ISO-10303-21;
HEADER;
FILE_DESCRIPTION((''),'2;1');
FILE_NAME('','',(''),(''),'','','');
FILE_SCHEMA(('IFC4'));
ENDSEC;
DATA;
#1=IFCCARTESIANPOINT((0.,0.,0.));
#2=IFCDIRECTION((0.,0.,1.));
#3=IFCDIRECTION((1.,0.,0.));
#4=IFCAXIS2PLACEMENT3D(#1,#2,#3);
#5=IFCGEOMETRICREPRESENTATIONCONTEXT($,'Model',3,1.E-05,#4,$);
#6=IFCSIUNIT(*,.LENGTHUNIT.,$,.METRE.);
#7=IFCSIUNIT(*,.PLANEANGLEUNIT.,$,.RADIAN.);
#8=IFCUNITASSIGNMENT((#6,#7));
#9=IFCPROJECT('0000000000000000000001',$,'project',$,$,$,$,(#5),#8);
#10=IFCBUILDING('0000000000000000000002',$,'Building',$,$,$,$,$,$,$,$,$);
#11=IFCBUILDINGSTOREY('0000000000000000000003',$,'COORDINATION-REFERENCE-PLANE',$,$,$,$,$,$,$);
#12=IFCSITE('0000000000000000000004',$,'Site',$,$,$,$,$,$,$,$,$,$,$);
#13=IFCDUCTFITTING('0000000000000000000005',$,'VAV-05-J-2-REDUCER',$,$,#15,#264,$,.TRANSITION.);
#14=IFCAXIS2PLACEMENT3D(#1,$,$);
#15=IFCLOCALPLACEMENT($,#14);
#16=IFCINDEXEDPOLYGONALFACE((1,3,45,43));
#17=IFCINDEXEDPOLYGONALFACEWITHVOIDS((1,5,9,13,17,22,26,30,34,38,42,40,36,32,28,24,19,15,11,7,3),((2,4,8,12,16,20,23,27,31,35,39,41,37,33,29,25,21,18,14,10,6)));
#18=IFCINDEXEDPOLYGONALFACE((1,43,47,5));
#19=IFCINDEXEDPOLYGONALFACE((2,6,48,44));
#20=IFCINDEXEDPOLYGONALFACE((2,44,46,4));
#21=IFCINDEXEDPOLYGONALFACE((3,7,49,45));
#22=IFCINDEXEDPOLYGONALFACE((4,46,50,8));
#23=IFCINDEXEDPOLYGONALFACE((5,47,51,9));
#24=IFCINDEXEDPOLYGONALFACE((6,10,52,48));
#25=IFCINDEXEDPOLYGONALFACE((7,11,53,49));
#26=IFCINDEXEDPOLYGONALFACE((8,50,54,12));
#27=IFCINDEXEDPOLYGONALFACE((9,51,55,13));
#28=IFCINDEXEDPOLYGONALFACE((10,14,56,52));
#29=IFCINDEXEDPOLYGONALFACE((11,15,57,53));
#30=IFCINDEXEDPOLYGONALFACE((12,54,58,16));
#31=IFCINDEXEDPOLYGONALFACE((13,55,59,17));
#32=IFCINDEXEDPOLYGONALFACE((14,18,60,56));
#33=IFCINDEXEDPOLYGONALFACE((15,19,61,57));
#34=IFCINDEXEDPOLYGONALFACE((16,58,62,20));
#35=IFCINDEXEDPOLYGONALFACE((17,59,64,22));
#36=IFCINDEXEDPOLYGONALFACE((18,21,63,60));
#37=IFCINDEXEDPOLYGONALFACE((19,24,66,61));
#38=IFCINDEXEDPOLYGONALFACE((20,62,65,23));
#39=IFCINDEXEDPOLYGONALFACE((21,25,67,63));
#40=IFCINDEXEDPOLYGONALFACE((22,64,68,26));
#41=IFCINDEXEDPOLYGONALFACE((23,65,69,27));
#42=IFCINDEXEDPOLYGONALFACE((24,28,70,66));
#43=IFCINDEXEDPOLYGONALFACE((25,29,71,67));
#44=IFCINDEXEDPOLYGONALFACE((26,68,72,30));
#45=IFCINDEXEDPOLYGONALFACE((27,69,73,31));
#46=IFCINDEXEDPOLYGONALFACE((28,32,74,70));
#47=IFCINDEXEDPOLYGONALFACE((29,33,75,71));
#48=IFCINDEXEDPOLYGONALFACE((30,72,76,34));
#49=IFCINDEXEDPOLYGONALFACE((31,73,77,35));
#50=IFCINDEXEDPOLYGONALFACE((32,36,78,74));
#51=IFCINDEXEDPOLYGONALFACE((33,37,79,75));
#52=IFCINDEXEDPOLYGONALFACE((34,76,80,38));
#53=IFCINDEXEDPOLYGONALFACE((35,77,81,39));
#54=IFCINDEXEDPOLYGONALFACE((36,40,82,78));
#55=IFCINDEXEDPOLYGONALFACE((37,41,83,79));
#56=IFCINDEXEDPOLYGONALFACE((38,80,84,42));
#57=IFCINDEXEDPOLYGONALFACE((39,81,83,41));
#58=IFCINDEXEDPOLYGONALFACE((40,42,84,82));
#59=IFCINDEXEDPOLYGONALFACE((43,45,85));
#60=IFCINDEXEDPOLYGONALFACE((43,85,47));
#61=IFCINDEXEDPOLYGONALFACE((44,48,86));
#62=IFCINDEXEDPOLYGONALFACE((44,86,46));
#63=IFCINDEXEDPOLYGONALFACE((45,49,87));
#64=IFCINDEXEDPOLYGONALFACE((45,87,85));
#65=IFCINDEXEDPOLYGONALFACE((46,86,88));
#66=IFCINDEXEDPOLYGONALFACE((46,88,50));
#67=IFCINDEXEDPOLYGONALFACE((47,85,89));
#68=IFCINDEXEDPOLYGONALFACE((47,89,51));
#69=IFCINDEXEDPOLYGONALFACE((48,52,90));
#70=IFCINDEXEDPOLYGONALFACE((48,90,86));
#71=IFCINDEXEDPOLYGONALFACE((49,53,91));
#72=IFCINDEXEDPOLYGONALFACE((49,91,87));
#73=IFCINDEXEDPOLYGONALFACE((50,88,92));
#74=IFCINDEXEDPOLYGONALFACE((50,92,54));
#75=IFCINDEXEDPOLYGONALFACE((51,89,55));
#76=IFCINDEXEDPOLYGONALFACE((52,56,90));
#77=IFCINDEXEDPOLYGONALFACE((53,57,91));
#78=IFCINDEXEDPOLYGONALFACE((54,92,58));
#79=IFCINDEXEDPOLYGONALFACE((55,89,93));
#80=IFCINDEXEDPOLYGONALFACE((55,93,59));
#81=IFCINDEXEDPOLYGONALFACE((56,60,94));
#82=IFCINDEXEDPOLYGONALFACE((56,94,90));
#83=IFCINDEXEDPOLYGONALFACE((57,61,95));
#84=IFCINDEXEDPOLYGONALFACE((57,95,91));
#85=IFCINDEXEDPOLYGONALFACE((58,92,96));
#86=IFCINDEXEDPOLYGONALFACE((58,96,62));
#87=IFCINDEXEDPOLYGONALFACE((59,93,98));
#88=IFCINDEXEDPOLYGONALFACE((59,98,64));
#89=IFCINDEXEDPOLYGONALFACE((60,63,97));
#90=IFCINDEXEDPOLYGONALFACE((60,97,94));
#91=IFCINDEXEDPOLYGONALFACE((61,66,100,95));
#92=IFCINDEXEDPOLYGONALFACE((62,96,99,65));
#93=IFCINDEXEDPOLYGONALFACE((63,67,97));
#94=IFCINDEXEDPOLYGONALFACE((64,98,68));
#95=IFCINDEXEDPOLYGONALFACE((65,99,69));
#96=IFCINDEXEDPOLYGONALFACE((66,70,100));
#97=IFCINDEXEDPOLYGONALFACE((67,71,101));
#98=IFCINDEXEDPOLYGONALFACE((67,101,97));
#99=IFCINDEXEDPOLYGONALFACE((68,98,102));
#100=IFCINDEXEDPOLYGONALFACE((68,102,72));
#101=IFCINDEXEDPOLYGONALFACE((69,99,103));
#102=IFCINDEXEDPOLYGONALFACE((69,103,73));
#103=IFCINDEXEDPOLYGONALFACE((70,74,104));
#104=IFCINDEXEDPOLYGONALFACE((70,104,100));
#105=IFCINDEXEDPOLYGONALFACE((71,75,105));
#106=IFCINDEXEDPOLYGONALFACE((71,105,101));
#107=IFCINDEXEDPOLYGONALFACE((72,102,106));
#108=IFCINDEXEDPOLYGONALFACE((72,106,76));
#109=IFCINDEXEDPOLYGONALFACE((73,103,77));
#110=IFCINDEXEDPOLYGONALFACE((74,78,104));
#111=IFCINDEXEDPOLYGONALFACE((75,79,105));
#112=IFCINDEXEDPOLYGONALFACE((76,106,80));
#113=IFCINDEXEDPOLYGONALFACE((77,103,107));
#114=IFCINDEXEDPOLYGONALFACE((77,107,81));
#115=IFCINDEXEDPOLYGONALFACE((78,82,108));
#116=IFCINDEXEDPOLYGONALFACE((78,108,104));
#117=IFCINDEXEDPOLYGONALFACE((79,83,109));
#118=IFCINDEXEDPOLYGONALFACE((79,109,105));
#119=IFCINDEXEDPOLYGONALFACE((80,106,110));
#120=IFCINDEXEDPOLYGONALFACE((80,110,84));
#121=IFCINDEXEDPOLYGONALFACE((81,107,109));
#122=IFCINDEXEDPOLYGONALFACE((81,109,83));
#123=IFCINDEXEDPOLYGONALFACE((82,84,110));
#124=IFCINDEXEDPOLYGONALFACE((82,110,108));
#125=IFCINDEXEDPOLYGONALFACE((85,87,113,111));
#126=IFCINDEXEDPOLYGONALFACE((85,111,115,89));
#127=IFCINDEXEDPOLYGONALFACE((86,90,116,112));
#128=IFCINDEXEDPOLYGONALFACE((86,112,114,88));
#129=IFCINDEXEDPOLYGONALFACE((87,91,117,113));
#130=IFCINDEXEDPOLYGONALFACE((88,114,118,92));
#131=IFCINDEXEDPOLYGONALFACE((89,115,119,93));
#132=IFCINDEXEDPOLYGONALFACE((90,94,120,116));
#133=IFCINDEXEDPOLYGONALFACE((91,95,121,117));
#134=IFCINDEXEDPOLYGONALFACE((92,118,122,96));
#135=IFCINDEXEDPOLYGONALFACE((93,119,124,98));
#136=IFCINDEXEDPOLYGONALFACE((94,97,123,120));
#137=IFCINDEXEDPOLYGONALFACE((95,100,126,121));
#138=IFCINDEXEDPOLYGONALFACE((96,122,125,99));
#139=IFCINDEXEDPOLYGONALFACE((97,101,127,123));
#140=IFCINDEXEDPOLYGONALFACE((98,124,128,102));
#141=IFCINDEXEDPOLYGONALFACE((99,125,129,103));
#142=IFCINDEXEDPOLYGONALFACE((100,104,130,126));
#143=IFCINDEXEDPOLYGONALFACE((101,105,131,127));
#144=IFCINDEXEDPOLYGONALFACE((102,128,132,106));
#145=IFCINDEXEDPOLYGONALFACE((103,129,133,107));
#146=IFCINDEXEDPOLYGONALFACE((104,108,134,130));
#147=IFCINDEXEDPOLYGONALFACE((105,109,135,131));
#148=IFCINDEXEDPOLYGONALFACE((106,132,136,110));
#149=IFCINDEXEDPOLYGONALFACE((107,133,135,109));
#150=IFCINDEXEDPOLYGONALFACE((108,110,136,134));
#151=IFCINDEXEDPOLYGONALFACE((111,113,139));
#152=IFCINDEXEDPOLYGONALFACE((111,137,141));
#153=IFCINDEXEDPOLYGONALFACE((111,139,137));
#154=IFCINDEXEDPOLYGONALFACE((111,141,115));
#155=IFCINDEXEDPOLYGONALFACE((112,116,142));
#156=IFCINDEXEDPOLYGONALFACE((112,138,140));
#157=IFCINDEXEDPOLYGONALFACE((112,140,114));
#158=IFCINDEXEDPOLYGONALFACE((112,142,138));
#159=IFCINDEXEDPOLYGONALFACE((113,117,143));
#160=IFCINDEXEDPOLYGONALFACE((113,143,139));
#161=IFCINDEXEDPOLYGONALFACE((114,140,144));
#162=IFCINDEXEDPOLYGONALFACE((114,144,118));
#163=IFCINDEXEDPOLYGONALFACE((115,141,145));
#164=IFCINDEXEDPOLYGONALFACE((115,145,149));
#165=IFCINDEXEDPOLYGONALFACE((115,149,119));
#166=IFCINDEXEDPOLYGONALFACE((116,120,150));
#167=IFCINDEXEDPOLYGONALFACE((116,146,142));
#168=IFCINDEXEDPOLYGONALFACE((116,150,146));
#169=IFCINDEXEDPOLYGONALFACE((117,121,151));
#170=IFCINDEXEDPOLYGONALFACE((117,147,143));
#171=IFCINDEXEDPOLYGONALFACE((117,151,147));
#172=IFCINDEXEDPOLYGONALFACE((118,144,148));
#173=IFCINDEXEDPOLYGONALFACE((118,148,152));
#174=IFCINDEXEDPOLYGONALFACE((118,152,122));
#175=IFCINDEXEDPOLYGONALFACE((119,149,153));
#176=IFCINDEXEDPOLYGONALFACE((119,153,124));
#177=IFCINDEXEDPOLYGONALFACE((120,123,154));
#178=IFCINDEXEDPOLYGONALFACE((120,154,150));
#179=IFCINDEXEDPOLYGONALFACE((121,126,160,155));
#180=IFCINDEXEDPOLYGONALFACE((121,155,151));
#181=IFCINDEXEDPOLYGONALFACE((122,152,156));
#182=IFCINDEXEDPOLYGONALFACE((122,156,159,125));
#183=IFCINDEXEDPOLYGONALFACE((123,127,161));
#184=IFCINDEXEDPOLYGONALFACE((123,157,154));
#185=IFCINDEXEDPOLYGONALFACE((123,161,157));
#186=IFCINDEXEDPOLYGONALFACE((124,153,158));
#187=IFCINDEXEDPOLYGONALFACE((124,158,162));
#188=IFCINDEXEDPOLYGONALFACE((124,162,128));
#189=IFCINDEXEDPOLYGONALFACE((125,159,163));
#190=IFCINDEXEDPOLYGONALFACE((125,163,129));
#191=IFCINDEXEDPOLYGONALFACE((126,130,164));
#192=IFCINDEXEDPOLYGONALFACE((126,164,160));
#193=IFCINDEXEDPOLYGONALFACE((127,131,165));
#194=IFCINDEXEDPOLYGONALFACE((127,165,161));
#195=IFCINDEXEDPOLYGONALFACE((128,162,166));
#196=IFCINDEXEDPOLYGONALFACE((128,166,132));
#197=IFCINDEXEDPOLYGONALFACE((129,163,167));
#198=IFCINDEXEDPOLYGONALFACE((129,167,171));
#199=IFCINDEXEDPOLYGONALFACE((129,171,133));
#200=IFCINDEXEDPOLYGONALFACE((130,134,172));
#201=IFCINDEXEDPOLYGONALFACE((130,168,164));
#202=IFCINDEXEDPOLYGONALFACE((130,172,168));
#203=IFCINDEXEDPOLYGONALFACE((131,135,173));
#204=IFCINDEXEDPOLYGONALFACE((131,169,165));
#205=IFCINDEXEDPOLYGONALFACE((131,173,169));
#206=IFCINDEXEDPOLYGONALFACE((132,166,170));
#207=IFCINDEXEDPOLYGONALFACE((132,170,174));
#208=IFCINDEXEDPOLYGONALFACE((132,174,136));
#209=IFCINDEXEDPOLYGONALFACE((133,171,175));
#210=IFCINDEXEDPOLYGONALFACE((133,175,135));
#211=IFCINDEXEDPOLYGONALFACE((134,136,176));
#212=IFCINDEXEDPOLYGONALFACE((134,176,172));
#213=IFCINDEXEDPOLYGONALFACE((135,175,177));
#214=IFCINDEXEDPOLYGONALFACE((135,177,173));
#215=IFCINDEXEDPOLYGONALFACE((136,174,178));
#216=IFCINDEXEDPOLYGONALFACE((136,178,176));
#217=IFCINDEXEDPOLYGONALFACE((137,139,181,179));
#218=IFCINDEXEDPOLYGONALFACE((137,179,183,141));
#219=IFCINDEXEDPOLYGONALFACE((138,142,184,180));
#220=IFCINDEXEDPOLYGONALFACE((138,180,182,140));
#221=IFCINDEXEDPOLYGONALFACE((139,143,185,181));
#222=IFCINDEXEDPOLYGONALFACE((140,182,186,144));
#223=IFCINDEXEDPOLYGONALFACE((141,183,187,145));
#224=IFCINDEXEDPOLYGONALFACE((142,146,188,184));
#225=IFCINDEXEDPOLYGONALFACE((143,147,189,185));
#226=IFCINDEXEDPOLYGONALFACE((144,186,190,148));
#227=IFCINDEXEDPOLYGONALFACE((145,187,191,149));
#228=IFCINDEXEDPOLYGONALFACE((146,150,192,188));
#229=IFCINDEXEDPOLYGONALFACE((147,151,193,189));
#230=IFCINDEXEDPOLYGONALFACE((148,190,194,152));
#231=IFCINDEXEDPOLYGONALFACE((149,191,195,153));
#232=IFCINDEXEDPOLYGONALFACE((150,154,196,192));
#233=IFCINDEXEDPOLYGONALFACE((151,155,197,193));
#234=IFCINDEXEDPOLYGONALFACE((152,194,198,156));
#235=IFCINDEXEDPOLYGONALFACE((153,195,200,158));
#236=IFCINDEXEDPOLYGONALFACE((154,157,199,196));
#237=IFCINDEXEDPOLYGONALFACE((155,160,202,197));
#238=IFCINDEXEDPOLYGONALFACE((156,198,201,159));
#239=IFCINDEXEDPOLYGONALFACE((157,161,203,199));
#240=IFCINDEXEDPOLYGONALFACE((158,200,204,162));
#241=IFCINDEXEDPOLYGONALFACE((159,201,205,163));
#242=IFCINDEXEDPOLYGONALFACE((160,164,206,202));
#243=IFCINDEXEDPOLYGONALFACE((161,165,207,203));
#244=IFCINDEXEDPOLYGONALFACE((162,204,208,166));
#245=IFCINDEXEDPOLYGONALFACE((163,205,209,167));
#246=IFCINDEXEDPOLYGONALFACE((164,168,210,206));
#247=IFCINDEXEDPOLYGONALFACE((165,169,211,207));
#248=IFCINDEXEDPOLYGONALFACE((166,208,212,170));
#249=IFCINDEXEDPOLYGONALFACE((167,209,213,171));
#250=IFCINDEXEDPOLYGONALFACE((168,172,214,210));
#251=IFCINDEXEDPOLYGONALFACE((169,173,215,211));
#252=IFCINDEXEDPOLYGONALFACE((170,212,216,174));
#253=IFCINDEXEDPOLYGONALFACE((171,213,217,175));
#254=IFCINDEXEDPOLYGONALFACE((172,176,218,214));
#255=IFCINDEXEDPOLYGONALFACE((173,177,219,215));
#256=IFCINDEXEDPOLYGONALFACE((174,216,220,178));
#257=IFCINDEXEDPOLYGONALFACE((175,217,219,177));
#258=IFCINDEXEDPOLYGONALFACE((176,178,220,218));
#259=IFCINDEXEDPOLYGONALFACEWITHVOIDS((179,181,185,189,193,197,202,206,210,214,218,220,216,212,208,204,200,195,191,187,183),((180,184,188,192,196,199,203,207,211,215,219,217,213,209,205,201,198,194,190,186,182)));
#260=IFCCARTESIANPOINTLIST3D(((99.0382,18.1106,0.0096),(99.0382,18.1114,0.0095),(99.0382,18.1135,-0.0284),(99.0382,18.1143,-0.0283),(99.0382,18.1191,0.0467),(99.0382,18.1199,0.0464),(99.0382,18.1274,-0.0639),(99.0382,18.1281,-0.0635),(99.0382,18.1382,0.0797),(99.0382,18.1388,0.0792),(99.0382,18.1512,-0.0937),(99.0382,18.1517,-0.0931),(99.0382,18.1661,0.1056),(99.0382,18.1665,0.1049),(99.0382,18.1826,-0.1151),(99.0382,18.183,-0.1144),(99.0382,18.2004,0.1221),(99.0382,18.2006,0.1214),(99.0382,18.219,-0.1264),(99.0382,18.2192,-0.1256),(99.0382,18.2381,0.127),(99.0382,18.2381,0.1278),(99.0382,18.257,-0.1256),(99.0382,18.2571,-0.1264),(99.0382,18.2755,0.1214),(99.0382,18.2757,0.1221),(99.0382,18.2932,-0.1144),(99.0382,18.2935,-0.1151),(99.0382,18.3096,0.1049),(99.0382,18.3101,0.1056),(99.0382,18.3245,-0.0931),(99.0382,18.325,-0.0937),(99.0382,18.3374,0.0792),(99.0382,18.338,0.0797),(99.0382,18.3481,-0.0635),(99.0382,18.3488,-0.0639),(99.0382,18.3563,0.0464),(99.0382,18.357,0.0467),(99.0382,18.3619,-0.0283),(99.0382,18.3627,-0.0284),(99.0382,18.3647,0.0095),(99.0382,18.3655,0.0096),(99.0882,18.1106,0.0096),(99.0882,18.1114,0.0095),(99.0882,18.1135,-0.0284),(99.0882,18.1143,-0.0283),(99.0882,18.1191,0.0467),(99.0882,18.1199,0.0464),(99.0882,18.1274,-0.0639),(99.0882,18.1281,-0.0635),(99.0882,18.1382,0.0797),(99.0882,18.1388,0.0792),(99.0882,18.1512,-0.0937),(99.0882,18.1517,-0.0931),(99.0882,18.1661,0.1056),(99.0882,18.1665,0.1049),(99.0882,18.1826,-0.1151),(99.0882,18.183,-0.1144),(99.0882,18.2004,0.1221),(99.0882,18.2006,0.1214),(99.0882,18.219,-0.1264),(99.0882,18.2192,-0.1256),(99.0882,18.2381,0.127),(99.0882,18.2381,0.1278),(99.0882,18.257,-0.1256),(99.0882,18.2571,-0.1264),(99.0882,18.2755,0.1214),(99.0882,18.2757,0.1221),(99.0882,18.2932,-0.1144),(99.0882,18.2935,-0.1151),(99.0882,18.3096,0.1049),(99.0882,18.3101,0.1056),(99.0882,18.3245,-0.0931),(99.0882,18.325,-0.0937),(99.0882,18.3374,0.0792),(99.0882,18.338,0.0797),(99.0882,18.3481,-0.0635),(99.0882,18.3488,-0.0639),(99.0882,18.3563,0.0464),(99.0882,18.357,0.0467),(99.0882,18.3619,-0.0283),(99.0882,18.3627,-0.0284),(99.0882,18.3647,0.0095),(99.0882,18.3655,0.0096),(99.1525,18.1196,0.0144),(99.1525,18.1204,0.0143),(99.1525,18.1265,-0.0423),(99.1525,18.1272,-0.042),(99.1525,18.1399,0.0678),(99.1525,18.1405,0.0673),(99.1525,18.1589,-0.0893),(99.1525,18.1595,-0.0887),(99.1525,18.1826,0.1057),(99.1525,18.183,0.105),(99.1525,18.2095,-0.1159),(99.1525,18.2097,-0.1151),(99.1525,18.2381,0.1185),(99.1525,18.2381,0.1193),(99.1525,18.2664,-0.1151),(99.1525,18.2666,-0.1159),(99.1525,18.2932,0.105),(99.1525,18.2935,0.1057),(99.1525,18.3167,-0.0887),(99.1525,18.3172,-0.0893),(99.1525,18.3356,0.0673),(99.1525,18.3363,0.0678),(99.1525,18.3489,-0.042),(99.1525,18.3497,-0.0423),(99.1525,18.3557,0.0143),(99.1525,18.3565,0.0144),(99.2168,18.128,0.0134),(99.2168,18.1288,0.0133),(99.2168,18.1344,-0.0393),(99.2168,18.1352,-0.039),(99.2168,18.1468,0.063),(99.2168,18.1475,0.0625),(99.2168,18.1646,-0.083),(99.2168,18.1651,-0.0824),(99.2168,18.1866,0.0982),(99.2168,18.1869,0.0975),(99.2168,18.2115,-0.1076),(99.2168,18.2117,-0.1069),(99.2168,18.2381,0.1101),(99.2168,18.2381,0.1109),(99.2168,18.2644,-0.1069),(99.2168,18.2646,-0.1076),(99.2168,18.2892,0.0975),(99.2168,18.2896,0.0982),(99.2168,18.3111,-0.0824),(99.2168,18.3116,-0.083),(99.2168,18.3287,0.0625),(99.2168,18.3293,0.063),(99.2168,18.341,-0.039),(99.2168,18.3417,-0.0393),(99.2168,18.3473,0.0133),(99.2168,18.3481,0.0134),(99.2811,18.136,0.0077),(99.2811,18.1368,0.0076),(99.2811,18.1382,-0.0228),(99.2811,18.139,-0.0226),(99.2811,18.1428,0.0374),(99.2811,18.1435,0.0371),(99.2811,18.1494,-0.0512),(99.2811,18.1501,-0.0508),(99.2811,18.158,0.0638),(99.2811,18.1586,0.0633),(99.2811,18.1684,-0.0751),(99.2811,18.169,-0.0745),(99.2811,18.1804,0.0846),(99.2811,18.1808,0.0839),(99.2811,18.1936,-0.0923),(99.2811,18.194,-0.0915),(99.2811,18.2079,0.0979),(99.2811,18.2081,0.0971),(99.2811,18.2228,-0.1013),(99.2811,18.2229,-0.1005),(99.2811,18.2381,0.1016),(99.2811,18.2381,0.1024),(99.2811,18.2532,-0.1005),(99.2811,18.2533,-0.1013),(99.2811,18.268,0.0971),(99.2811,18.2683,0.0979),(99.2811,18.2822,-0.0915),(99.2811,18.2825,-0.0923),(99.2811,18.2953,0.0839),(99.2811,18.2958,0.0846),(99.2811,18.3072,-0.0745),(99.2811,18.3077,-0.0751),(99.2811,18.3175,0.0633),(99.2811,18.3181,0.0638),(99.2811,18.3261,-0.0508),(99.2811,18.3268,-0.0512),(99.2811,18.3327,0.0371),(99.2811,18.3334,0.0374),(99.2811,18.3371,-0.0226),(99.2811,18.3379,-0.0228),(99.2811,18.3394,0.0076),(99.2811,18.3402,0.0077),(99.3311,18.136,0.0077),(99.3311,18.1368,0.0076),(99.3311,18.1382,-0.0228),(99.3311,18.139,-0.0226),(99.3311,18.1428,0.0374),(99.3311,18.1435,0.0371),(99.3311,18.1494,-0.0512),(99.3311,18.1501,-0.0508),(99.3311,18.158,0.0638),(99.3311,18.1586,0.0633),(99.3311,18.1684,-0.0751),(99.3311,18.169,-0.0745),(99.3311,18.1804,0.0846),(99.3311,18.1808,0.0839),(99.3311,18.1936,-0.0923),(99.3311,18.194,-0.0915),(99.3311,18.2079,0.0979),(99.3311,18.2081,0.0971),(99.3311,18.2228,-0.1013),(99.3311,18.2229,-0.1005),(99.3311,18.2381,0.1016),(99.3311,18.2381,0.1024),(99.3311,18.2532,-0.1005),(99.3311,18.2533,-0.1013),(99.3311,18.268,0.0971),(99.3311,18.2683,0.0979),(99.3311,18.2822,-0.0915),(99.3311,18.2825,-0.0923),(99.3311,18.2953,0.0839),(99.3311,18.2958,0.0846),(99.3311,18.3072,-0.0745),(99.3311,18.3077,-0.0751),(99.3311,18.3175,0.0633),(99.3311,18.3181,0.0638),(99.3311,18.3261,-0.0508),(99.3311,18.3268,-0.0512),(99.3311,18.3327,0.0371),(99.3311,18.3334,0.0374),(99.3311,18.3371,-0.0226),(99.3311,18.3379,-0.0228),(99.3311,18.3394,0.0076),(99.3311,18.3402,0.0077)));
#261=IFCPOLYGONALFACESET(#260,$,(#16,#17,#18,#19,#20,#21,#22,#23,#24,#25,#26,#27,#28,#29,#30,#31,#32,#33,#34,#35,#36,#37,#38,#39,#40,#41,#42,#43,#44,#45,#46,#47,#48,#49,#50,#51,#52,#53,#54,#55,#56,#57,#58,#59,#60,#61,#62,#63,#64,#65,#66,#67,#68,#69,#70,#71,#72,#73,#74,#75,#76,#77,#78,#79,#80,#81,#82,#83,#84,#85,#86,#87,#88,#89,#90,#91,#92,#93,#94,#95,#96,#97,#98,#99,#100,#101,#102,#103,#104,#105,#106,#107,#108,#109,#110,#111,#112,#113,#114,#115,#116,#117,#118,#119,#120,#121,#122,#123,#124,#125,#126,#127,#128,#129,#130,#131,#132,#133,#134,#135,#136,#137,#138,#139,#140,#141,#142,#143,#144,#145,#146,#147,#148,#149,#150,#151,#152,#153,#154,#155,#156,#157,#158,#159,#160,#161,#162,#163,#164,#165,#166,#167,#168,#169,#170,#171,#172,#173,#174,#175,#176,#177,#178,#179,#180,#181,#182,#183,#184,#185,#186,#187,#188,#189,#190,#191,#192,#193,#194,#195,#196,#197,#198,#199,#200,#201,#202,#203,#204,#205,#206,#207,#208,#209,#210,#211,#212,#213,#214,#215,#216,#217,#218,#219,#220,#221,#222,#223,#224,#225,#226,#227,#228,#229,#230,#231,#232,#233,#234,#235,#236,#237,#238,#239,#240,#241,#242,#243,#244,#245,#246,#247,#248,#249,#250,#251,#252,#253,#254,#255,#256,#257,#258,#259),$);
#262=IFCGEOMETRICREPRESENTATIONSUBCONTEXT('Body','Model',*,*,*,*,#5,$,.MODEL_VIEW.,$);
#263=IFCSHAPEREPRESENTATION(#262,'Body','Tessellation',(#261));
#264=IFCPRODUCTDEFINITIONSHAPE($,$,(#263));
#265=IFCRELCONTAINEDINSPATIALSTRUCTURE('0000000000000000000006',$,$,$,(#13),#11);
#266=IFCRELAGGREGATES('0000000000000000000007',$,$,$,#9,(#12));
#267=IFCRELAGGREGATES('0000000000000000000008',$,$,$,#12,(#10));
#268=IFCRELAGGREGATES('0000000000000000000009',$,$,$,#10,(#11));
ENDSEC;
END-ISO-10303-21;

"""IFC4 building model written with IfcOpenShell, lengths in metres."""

from ifc_helpers import new_model, entity, si_unit, frame, origin_with_axes, place, context, subcontext, project, spatial, element, save


model = new_model("IFC4")

# Units and contexts
model_context = context("Model", 3, precision=1e-05, world=origin_with_axes())
body_context_1 = subcontext(model_context, "Body", "Model", "MODEL_VIEW")
ifc_project = project(units=[si_unit("LENGTHUNIT", "METRE"), si_unit("PLANEANGLEUNIT", "RADIAN")], contexts=[model_context])

# Site, building, storey
site = spatial("IfcSite", under=ifc_project, Name="Site")
building = spatial("IfcBuilding", under=site, Name="Building")
storey = spatial("IfcBuildingStorey", under=building, Name="COORDINATION-REFERENCE-PLANE")

# Duct fitting
for number, where, z_axis, x_axis, name in (
    (1, (99.0382, 18.2381, 0.0), (0.0, 1.0, 0.0), (0.0, 0.0, 1.0), "VAV-05-J-2-REDUCER"),
):
    element("IfcDuctFitting", number, at=place(None, frame(where, z_axis=z_axis, x_axis=x_axis)), inside=storey, Name=name, PredefinedType="TRANSITION", context=body_context_1, shape_type="SweptSolid", body=[
        entity("IfcRevolvedAreaSolid", entity("IfcArbitraryClosedProfileDef", "AREA", None, entity("IfcPolyline", [entity("IfcCartesianPoint", [0.1278, 0.0]), entity("IfcCartesianPoint", [0.1278, 0.05]), entity("IfcCartesianPoint", [0.1024, 0.2429]), entity("IfcCartesianPoint", [0.1024, 0.2929]), entity("IfcCartesianPoint", [0.1016, 0.2929]), entity("IfcCartesianPoint", [0.1016, 0.2429]), entity("IfcCartesianPoint", [0.127, 0.05]), entity("IfcCartesianPoint", [0.127, 0.0]), entity("IfcCartesianPoint", [0.1278, 0.0])])), entity("IfcAxis2Placement3D", entity("IfcCartesianPoint", [0.0, 0.0, 0.0])), entity("IfcAxis1Placement", entity("IfcCartesianPoint", [0.0, 0.0, 0.0]), entity("IfcDirection", [0.0, 1.0, 0.0])), 6.283185),
    ])

save(model, "model.ifc")
